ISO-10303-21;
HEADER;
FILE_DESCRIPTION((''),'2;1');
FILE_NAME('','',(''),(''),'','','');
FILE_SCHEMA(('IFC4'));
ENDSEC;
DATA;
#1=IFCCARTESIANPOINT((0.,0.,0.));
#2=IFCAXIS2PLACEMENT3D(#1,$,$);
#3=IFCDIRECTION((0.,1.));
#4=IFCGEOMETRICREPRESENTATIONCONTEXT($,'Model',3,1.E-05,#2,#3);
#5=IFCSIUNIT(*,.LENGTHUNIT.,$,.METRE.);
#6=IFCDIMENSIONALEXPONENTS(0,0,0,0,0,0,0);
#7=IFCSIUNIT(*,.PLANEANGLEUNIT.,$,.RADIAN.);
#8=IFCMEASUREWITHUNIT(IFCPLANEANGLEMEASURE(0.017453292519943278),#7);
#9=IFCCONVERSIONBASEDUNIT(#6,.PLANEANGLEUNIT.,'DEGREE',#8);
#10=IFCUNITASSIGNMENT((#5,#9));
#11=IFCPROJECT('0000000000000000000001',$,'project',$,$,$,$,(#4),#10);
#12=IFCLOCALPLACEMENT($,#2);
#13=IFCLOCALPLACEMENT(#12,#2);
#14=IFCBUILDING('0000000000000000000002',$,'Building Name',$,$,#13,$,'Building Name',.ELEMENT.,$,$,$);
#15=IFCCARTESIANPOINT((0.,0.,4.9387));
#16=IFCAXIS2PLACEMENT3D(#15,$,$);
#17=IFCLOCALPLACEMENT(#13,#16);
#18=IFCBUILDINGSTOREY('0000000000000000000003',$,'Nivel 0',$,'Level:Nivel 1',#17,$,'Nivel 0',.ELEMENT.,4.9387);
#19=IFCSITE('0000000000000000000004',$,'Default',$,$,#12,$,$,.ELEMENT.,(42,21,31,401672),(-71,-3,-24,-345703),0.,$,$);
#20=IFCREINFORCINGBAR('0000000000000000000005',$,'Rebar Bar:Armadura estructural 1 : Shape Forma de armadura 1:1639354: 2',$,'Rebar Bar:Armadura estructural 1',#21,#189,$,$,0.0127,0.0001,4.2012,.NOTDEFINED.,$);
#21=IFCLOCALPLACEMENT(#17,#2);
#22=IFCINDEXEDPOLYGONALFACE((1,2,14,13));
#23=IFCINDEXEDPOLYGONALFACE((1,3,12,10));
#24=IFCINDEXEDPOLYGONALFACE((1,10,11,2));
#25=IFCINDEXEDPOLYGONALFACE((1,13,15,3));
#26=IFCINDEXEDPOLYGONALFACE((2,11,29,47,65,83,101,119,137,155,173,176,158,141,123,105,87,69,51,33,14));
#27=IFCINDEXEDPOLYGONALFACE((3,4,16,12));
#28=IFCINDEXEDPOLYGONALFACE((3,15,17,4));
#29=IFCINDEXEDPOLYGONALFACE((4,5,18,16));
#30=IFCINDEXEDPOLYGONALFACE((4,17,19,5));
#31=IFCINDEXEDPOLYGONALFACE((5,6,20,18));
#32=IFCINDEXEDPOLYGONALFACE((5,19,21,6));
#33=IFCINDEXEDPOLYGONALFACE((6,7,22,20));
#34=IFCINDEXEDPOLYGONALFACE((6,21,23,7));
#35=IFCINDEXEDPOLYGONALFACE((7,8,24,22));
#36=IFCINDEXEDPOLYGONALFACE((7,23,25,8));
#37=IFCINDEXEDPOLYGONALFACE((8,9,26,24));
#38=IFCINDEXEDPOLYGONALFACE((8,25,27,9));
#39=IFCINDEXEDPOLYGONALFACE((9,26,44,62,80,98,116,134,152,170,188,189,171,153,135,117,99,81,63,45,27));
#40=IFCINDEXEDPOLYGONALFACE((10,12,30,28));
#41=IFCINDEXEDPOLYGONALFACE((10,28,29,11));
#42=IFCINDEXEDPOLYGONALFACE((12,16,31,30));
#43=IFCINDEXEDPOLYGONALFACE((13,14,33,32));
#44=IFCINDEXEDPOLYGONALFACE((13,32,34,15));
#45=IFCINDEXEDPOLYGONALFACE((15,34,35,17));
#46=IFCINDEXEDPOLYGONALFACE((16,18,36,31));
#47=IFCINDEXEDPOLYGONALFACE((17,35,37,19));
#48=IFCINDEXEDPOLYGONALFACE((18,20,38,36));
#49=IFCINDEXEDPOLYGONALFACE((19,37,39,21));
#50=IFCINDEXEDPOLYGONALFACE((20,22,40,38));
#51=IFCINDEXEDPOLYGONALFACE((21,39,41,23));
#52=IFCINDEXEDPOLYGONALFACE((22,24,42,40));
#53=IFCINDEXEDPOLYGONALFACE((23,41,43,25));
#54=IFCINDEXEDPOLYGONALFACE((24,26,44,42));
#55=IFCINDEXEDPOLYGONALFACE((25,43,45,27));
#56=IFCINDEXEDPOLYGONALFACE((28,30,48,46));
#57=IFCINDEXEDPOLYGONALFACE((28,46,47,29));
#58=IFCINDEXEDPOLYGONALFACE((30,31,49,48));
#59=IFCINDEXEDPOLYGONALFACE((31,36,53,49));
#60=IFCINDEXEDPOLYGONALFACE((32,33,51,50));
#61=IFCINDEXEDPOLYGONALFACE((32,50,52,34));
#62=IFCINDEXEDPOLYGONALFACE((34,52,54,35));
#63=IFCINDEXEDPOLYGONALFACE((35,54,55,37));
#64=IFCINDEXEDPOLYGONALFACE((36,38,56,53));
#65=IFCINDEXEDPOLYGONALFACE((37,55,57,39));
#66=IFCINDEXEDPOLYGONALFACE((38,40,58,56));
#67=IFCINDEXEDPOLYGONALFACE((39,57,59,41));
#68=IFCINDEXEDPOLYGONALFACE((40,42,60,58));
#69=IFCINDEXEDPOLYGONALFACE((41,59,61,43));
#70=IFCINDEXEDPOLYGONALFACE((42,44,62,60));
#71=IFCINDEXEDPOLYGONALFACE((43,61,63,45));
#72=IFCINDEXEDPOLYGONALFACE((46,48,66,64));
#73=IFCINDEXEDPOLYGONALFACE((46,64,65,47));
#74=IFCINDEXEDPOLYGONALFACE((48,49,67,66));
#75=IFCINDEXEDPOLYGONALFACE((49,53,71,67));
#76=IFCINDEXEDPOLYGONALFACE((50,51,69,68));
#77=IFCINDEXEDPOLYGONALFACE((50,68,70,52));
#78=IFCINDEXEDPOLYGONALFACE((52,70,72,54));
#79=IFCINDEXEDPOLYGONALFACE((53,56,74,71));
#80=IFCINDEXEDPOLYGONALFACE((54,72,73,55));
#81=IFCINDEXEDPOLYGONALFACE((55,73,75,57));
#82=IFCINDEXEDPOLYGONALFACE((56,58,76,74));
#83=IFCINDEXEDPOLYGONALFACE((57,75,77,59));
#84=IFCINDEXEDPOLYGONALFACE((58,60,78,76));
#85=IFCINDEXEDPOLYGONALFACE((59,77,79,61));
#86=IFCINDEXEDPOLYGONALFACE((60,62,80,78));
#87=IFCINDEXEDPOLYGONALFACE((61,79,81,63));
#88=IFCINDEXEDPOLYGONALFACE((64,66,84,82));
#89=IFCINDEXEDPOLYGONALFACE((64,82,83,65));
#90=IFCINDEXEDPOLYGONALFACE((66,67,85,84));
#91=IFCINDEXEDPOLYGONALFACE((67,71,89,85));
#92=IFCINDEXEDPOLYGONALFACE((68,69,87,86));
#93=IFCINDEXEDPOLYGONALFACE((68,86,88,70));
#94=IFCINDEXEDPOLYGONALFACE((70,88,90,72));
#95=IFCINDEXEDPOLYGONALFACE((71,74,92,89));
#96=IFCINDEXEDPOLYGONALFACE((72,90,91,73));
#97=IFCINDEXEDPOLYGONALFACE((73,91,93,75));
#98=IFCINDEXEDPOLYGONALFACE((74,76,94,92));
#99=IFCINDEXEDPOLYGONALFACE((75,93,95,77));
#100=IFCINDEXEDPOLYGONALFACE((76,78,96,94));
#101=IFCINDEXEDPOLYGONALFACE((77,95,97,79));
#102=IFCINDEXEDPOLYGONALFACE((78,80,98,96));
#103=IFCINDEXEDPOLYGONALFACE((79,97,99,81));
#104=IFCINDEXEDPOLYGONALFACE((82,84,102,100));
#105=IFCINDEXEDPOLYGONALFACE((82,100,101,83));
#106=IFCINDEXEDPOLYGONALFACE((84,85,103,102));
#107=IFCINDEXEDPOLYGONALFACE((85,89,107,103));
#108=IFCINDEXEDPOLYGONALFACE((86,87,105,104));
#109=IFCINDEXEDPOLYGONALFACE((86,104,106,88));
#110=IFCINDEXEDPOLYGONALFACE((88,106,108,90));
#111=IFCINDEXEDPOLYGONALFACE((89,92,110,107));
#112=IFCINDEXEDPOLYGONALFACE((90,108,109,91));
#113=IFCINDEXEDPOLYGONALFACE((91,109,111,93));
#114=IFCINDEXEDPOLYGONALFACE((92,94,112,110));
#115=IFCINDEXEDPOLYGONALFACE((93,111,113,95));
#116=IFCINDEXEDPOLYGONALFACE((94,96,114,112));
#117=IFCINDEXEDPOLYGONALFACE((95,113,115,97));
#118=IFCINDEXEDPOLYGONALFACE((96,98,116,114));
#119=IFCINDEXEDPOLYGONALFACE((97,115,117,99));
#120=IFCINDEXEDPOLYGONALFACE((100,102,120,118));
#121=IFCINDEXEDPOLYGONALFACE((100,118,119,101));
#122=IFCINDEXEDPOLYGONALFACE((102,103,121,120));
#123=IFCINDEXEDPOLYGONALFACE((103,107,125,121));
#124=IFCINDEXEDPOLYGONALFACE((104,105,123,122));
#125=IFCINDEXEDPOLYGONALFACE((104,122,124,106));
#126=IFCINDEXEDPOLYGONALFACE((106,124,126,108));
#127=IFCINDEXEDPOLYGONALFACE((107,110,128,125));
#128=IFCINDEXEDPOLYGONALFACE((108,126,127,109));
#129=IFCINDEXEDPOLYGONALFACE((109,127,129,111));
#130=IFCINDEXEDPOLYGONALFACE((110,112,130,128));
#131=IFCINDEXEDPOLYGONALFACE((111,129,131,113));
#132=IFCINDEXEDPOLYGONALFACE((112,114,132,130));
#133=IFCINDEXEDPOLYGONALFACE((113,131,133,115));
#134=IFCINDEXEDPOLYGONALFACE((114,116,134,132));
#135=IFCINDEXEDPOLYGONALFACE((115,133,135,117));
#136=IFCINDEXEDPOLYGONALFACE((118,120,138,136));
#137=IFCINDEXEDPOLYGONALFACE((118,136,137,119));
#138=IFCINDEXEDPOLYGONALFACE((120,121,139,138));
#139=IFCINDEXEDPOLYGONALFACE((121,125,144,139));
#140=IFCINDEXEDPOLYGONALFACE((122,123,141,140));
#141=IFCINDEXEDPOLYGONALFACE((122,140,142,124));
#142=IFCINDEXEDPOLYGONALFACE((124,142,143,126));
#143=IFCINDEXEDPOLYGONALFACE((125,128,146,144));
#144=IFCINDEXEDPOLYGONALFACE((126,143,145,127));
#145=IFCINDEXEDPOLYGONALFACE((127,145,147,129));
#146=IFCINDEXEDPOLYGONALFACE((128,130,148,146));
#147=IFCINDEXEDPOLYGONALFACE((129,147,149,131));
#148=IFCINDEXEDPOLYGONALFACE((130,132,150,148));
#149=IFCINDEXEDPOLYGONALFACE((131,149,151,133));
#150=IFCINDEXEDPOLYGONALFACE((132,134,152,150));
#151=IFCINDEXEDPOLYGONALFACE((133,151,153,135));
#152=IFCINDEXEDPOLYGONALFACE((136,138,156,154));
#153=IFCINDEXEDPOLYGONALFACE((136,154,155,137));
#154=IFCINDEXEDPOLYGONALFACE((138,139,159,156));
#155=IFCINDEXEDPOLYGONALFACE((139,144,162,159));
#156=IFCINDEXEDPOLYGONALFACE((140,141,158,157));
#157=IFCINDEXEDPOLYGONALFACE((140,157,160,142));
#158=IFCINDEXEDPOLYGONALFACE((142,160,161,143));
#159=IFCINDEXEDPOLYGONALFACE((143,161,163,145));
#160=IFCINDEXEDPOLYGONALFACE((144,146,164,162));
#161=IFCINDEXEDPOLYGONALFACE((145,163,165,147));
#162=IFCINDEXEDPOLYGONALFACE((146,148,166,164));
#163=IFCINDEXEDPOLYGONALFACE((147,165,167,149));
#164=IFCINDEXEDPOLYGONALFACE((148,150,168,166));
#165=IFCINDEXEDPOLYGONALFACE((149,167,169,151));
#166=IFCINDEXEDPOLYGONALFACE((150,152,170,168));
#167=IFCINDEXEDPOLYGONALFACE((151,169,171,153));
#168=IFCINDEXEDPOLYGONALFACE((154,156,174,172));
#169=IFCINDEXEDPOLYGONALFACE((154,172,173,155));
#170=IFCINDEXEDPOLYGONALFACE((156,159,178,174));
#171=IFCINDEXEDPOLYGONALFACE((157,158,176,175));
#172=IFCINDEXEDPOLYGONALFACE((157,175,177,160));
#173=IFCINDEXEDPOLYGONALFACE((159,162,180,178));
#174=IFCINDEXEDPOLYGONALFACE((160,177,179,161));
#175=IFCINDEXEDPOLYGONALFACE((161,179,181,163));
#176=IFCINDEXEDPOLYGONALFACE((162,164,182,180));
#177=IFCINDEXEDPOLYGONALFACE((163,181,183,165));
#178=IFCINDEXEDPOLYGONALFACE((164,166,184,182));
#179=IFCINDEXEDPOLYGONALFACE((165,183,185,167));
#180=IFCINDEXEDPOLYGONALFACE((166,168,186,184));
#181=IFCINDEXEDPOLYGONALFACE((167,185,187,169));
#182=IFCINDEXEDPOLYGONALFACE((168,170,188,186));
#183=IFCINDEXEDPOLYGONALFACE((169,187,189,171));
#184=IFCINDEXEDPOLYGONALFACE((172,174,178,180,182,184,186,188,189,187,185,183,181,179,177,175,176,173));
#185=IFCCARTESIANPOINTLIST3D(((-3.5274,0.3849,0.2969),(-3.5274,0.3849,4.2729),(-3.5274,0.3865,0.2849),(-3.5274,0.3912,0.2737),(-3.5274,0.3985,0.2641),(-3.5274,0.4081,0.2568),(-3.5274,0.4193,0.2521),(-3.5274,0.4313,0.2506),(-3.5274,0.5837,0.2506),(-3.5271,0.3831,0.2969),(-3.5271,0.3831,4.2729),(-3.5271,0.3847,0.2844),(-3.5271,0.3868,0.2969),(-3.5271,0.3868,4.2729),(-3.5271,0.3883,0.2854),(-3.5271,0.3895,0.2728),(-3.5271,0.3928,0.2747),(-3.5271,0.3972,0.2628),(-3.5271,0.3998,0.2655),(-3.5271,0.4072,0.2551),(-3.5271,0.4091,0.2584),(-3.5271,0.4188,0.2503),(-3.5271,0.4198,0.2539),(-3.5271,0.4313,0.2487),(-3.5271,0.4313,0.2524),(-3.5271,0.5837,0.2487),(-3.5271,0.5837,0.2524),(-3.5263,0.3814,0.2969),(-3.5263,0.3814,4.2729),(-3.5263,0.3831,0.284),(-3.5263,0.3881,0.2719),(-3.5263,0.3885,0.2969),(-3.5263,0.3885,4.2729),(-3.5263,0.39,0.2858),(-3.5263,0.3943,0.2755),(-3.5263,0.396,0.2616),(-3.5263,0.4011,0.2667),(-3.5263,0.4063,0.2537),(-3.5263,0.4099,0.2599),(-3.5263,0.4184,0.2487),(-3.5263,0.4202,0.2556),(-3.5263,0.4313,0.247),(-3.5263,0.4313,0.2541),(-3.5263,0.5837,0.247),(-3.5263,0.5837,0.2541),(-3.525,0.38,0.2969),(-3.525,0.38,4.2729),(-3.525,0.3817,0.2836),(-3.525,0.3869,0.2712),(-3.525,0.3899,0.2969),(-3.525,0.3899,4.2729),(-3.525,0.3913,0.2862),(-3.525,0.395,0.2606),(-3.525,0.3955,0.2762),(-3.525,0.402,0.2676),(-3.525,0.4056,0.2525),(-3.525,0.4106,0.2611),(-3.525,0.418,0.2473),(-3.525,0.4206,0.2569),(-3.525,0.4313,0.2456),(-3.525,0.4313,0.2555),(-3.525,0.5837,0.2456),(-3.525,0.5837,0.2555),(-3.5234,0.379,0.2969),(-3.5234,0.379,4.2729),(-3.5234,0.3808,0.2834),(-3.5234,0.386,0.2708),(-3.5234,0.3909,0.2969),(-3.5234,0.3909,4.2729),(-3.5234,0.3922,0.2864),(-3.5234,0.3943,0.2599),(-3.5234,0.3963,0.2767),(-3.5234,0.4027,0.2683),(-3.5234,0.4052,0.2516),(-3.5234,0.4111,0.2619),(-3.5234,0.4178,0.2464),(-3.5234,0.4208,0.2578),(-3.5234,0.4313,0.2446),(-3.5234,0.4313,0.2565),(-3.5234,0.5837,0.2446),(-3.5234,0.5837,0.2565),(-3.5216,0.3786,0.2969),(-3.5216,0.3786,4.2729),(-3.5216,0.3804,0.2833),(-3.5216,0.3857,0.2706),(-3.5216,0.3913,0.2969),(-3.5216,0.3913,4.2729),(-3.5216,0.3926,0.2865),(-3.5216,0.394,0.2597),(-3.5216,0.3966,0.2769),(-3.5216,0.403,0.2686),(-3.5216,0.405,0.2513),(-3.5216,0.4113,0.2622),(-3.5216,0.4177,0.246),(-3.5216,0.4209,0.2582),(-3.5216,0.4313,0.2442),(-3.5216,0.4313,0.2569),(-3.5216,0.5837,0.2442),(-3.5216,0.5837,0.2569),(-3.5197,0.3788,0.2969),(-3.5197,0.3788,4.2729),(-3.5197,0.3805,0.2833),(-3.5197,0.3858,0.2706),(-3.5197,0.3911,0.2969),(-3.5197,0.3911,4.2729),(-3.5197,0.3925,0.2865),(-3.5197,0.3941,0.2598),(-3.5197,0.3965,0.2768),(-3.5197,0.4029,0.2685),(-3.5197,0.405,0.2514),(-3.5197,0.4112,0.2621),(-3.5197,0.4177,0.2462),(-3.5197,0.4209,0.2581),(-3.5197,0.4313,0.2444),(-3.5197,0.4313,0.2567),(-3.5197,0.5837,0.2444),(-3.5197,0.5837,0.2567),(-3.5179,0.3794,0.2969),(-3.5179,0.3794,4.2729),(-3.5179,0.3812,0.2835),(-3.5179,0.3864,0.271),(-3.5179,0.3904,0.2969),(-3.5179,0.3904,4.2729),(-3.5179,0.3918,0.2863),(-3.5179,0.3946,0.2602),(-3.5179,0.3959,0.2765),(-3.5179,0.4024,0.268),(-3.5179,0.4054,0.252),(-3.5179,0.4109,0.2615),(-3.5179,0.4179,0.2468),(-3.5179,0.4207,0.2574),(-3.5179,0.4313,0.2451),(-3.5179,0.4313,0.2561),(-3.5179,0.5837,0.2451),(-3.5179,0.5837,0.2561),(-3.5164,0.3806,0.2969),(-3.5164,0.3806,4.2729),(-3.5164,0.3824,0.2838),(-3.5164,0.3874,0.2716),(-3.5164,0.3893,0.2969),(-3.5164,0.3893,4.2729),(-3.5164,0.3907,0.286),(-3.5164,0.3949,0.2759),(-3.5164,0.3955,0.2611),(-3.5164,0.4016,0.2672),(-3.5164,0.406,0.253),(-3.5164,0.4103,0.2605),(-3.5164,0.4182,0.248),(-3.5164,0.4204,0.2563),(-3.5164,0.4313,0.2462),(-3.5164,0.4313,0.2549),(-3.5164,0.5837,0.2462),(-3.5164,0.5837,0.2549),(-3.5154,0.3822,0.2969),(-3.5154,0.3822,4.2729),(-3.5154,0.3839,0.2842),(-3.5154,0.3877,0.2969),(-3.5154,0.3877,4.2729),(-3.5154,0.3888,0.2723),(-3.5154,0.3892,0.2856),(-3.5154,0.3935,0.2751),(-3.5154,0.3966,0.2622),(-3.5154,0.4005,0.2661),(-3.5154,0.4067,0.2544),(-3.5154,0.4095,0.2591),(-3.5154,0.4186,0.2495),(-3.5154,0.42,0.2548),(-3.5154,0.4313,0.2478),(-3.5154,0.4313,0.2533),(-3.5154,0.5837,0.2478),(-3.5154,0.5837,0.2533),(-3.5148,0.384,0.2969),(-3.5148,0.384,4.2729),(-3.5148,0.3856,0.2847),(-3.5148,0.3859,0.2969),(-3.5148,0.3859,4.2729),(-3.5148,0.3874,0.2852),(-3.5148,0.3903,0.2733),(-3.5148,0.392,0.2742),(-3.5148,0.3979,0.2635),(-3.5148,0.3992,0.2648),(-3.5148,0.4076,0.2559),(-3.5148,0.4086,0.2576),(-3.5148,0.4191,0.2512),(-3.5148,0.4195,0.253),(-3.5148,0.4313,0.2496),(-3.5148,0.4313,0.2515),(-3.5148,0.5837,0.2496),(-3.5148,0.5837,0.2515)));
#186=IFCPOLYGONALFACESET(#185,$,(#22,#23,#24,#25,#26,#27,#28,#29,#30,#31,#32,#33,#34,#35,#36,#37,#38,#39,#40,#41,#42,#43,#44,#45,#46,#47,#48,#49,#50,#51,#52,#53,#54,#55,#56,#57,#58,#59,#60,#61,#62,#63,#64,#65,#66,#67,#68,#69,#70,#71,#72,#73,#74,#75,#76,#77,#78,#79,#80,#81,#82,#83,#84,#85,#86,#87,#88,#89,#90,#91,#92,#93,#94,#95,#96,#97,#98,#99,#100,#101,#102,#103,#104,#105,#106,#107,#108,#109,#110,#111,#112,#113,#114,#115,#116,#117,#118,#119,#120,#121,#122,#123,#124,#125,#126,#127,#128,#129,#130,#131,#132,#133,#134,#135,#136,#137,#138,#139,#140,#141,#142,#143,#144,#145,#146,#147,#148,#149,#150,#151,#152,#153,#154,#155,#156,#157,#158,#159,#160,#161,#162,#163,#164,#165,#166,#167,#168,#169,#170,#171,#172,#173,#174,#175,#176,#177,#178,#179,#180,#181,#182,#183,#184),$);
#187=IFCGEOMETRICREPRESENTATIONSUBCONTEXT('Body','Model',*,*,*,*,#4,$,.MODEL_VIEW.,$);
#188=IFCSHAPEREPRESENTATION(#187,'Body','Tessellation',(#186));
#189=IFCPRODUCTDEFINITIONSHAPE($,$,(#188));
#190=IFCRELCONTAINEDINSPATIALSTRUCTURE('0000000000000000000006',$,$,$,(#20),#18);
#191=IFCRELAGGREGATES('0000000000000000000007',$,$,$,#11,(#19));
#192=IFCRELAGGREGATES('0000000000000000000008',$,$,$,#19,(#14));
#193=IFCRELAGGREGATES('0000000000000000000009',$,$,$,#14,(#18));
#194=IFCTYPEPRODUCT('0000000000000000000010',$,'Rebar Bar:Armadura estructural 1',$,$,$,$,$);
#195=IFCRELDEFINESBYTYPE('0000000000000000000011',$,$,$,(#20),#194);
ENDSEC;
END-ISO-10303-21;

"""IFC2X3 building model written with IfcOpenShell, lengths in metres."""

from ifc_helpers import new_model, entity, si_unit, converted_unit, direction, frame, origin, place, context, subcontext, project, spatial, type_object, element, save


model = new_model("IFC2X3")

# Units and contexts
model_context = context("Model", 3, precision=1e-05, world=origin(), true_north=direction((0.0, 1.0)))
body_context = subcontext(model_context, "Body", "Model", "MODEL_VIEW")
ifc_project = project(units=[si_unit("LENGTHUNIT", "METRE"), converted_unit("PLANEANGLEUNIT", "DEGREE", entity("IfcPlaneAngleMeasure", 0.017453292519943278), si_unit("PLANEANGLEUNIT", "RADIAN"), dimensions=[0, 0, 0, 0, 0, 0, 0])], contexts=[model_context])

# Site, building, storey
site_placement = place(None, origin())
site = spatial("IfcSite", under=ifc_project, at=site_placement, Name="Default", CompositionType="ELEMENT", RefLatitude=(42, 21, 31, 401672), RefLongitude=(-71, -3, -24, -345703), RefElevation=0.0)
building_placement = place(site_placement, origin())
building = spatial("IfcBuilding", under=site, at=building_placement, Name="Building Name", LongName="Building Name", CompositionType="ELEMENT")
storey_placement = place(building_placement, frame((0.0, 0.0, 4.9387)))
storey = spatial("IfcBuildingStorey", under=building, at=storey_placement, Name="Nivel 0", ObjectType="Level:Nivel 1", LongName="Nivel 0", CompositionType="ELEMENT", Elevation=4.9387)

# Reinforcing bar
type_product = type_object("IfcTypeProduct", Name="Rebar Bar:Armadura estructural 1")
reinforcing_bar_1_placement = place(storey_placement, origin())
element("IfcReinforcingBar", 1, at=reinforcing_bar_1_placement, inside=storey, type_object=type_product, Name="Rebar Bar:Armadura estructural 1 : Shape Forma de armadura 1:1639354: 2", ObjectType="Rebar Bar:Armadura estructural 1", BarLength=4.2012, BarRole="NOTDEFINED", CrossSectionArea=0.0001, NominalDiameter=0.0127, context=body_context, shape_type="AdvancedSweptSolid", body=[
    entity("IfcSweptDiskSolid", entity("IfcCompositeCurve", [entity("IfcCompositeCurveSegment", "CONTINUOUS", True, entity("IfcPolyline", [entity("IfcCartesianPoint", [-3.5211, 0.5837, 0.2506]), entity("IfcCartesianPoint", [-3.5211, 0.4313, 0.2506])])), entity("IfcCompositeCurveSegment", "CONTINUOUS", True, entity("IfcTrimmedCurve", entity("IfcCircle", entity("IfcAxis2Placement3D", entity("IfcCartesianPoint", [-3.5211, 0.4313, 0.2969]), entity("IfcDirection", [-1.0, 0.0, 0.0]), entity("IfcDirection", [0.0, -1.0, 0.0])), 0.0464), [entity("IfcParameterValue", 270.0)], [entity("IfcParameterValue", 360.0)], True, "PARAMETER")), entity("IfcCompositeCurveSegment", "CONTINUOUS", True, entity("IfcPolyline", [entity("IfcCartesianPoint", [-3.5211, 0.3849, 0.2969]), entity("IfcCartesianPoint", [-3.5211, 0.3849, 4.2729])]))], False), 0.0063, None, 0.0, 92.0),
])

save(model, "model.ifc")
